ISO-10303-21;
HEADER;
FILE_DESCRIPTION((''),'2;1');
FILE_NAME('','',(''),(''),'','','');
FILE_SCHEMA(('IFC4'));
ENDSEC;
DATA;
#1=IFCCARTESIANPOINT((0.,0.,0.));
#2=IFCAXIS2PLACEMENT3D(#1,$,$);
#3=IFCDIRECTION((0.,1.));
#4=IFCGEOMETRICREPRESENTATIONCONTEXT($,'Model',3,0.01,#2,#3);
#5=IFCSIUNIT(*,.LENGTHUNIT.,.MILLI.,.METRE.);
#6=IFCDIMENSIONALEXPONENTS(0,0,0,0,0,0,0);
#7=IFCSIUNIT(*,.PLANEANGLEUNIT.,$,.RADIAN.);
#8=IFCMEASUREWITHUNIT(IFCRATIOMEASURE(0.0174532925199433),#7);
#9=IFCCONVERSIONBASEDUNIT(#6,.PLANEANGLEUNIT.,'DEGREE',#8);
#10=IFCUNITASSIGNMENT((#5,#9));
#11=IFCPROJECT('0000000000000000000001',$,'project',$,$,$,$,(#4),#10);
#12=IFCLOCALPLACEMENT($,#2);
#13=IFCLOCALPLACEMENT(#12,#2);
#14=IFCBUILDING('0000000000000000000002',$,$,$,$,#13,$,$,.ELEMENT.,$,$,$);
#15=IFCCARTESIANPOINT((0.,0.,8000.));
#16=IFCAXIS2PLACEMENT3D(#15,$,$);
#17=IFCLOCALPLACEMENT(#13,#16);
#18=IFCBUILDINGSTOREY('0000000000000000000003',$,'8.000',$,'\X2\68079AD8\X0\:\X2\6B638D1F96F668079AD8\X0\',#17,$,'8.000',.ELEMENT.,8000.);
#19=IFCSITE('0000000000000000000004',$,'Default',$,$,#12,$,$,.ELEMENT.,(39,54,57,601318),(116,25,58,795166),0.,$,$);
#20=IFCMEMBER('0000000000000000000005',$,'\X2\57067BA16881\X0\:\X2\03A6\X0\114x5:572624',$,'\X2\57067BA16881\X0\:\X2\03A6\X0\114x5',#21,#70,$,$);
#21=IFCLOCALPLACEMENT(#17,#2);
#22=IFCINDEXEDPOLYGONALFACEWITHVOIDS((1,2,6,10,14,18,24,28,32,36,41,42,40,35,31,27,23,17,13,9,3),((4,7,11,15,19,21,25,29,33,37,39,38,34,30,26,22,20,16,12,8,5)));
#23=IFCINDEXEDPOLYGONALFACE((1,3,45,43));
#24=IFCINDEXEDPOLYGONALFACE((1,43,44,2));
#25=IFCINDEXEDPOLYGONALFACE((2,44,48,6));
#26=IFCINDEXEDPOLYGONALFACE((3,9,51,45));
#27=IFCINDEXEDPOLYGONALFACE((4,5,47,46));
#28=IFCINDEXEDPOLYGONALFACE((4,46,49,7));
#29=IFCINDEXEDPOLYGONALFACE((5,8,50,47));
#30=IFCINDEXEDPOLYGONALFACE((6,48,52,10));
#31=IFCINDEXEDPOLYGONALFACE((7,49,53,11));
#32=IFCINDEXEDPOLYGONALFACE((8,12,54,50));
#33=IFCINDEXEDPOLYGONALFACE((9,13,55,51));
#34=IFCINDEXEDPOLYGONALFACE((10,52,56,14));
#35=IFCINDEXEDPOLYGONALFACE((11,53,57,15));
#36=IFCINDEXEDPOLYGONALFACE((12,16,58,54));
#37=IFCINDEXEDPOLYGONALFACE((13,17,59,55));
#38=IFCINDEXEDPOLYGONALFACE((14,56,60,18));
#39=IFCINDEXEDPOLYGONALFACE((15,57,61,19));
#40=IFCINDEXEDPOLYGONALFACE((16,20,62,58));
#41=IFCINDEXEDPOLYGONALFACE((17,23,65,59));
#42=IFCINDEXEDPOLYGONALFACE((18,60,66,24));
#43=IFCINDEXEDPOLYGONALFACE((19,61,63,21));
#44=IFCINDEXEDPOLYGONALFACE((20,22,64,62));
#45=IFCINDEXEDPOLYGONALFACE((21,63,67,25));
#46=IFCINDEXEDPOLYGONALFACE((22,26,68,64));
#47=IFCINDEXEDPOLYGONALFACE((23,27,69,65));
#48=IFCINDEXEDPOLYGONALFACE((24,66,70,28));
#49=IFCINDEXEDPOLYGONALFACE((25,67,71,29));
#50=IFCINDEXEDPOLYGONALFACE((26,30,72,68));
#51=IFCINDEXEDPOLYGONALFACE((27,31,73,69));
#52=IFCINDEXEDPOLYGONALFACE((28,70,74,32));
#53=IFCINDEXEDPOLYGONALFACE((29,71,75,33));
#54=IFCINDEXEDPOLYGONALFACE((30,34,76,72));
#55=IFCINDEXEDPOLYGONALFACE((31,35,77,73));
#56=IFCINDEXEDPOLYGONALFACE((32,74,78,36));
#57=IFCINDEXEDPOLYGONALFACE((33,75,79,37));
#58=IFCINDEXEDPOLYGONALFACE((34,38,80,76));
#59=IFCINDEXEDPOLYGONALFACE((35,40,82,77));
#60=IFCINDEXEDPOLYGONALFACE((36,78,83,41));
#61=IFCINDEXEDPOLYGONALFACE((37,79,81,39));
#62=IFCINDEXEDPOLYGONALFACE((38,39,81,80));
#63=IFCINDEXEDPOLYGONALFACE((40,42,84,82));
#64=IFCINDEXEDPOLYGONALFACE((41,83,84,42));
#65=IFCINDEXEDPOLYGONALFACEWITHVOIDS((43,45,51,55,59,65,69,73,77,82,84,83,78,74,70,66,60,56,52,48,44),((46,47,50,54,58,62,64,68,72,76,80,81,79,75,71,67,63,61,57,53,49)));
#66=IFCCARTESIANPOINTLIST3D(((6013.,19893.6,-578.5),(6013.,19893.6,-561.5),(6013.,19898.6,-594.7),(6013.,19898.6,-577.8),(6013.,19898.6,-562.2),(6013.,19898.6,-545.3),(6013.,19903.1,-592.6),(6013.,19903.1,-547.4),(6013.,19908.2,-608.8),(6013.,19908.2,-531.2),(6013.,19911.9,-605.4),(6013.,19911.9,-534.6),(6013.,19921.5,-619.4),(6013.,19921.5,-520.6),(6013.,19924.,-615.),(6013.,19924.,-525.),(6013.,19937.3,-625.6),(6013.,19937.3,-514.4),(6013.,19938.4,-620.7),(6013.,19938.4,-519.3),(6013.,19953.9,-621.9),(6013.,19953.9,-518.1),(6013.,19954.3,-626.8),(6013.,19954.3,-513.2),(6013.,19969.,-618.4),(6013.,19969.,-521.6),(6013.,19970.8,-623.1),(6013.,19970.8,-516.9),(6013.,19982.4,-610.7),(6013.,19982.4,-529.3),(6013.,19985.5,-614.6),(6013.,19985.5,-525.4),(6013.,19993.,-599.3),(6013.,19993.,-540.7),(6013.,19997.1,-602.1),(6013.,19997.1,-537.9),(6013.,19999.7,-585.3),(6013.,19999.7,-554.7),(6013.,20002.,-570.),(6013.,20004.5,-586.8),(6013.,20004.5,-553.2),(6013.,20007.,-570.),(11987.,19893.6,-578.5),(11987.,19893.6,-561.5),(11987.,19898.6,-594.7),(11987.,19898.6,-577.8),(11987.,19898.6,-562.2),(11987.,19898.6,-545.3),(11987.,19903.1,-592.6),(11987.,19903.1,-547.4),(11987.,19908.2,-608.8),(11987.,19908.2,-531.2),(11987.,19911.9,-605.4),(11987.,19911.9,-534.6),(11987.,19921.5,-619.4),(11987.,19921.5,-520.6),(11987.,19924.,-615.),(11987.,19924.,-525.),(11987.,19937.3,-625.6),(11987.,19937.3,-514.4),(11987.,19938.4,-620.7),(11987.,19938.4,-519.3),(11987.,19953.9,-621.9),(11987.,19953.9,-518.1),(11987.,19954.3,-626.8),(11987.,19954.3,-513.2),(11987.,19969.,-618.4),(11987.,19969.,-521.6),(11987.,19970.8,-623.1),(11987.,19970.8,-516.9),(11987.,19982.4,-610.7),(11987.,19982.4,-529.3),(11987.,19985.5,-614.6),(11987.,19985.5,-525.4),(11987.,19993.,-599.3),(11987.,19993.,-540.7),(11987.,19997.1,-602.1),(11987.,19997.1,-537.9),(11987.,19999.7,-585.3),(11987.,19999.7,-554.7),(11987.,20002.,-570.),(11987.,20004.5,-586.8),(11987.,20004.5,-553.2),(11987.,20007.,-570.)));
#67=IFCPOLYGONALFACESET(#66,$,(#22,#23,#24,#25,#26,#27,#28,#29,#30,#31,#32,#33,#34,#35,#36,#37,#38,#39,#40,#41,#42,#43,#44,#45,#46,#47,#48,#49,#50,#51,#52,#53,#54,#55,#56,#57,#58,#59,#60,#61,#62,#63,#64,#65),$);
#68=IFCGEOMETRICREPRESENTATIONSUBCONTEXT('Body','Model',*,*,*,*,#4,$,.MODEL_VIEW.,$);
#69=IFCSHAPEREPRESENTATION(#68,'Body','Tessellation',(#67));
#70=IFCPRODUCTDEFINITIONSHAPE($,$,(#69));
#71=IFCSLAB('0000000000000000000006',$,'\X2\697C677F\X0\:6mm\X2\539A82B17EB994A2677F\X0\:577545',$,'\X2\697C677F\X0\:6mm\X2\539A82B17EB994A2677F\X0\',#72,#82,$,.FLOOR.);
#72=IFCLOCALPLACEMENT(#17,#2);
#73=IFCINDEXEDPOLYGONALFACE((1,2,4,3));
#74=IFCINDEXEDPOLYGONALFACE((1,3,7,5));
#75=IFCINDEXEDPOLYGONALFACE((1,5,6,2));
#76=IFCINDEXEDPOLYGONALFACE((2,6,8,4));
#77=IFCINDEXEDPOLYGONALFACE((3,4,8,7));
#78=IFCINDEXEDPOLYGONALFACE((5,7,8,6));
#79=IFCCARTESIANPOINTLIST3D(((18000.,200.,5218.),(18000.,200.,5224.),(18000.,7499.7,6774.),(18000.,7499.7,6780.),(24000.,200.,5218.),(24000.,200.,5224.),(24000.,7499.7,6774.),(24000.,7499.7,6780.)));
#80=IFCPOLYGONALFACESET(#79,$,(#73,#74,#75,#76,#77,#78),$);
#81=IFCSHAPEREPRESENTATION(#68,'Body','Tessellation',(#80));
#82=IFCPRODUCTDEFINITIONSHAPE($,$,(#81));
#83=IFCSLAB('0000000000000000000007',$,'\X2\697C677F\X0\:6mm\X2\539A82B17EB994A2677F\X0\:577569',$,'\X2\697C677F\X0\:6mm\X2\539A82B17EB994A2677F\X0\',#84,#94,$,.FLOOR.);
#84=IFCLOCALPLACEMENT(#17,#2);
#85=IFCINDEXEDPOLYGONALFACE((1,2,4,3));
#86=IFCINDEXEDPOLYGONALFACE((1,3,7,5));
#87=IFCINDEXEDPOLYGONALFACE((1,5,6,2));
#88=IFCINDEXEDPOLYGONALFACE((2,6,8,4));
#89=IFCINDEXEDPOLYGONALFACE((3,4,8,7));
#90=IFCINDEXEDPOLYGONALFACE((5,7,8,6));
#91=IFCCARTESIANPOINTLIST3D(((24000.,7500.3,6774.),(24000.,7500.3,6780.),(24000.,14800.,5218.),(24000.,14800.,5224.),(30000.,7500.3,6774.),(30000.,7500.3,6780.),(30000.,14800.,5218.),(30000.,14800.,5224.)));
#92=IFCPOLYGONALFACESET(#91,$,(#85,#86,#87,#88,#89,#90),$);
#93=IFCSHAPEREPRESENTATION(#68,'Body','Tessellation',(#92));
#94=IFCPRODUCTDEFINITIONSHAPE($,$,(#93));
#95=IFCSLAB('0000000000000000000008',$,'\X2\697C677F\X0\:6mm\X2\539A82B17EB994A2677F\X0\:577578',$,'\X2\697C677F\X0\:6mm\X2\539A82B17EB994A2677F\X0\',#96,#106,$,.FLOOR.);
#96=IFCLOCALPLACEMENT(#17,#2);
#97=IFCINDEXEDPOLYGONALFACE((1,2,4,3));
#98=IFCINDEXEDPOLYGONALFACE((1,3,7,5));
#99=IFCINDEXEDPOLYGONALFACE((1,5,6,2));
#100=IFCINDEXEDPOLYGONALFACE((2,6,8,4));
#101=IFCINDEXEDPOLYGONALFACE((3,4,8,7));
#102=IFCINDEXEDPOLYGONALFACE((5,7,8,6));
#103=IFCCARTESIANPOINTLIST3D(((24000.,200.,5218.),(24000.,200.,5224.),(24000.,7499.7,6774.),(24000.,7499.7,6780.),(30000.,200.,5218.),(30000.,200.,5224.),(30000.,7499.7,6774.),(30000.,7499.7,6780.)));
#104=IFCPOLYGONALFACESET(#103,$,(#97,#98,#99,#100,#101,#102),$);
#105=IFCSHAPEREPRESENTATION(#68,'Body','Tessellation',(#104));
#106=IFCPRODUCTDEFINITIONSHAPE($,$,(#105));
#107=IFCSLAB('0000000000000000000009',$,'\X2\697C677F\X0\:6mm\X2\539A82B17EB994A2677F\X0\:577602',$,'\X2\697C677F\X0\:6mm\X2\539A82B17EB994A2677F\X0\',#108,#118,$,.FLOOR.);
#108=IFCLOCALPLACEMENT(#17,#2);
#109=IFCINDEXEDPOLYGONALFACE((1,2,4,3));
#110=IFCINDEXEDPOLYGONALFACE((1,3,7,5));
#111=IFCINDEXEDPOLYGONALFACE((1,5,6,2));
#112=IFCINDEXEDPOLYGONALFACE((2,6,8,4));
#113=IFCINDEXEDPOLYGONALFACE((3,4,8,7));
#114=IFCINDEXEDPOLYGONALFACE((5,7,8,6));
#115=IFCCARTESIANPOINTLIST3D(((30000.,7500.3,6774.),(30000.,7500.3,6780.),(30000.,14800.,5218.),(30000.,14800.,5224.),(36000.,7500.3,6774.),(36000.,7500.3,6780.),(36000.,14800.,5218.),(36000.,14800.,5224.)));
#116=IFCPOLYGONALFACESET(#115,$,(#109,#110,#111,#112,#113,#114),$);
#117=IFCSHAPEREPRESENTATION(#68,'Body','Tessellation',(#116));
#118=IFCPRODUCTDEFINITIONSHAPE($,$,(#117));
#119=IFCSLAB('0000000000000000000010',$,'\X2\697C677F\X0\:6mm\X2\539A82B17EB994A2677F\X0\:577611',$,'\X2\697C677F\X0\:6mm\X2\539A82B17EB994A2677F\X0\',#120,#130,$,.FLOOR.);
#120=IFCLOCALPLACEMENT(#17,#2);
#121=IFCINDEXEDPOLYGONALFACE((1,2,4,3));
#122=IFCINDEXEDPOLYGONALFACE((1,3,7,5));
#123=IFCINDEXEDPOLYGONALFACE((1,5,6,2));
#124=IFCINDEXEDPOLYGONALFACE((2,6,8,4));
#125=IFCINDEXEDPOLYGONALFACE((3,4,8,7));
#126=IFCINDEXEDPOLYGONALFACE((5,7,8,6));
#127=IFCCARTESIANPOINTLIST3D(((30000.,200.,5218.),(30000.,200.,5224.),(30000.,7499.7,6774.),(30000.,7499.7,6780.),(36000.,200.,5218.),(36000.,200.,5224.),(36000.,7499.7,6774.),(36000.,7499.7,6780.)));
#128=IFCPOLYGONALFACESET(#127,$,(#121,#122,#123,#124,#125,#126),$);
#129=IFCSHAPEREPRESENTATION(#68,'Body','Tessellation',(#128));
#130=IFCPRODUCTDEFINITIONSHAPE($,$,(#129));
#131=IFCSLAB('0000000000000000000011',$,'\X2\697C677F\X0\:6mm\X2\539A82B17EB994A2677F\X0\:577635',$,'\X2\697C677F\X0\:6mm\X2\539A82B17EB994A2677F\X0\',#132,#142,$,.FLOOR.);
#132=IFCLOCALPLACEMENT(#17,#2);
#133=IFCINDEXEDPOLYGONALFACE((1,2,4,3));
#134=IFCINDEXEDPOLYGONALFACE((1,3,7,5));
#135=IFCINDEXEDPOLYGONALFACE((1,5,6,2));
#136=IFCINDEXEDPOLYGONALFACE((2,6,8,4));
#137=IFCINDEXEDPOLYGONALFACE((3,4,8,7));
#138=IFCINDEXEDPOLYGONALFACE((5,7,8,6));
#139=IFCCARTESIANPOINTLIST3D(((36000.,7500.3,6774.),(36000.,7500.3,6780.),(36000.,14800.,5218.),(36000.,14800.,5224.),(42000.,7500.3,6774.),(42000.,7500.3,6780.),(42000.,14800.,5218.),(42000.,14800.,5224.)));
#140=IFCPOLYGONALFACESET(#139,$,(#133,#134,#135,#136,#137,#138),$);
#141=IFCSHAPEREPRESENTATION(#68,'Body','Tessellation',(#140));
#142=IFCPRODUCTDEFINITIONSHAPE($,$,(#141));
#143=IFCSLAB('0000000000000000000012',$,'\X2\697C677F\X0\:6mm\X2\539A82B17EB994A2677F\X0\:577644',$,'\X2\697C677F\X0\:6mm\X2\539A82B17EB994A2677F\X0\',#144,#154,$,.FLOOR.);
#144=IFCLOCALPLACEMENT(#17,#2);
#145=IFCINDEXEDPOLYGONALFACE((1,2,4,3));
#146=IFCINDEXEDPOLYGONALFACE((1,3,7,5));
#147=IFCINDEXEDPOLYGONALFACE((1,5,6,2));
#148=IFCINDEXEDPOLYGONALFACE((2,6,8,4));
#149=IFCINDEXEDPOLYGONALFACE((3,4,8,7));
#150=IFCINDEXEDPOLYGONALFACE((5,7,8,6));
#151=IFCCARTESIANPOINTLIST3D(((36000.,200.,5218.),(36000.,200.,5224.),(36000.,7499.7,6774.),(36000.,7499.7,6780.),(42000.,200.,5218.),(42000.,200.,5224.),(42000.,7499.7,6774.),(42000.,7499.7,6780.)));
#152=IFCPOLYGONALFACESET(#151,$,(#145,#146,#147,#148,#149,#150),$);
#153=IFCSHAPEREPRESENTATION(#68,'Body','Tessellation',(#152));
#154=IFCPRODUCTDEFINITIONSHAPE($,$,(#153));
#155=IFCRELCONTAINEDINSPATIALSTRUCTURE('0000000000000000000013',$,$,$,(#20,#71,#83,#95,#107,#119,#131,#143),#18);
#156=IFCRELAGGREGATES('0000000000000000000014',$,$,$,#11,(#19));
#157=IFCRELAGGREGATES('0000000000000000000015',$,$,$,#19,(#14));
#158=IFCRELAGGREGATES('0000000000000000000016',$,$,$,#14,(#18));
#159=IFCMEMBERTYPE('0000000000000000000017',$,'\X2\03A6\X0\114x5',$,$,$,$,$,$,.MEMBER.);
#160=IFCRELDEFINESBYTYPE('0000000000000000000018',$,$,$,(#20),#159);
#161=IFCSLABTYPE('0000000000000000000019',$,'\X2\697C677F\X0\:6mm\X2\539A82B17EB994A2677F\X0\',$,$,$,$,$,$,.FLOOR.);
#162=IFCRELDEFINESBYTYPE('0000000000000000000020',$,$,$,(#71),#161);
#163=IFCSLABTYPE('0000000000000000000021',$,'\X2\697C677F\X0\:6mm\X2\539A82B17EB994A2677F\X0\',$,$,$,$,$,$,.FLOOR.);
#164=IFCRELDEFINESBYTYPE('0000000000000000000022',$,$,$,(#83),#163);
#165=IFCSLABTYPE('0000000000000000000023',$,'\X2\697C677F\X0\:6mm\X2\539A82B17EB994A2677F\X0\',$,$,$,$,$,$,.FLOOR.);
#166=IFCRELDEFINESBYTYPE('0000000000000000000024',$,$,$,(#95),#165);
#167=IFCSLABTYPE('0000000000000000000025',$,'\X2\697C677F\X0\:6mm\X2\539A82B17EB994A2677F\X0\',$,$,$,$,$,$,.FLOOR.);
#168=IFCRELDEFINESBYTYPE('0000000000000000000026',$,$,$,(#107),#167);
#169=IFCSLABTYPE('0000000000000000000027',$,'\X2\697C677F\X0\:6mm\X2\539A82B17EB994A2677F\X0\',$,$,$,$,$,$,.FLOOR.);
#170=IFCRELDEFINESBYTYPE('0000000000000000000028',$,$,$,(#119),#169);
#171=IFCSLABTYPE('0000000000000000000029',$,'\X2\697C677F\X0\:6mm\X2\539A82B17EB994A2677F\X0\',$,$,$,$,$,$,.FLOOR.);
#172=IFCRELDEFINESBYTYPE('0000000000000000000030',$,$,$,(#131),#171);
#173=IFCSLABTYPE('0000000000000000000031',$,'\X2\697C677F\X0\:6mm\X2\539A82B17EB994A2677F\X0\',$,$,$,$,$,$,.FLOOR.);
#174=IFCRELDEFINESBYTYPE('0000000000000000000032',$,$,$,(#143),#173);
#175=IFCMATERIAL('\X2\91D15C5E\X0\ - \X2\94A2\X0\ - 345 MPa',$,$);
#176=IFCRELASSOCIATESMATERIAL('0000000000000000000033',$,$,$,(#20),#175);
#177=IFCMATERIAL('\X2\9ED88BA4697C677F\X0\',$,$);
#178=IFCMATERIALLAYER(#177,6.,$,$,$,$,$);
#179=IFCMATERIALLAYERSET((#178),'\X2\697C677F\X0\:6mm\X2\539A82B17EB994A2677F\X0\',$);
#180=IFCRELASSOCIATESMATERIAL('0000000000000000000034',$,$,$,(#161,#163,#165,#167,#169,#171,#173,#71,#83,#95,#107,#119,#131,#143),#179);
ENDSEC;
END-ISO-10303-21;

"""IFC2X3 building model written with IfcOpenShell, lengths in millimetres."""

from ifc_helpers import new_model, entity, si_unit, converted_unit, direction, frame, frame_2d, origin, place, context, subcontext, project, spatial, rectangle, hollow_circle, extrude, clip, halfspace, source, transform, mapped, material, layer, layer_set, layer_usage, type_object, type_shapes, element, save


model = new_model("IFC2X3")

# Units and contexts
model_context = context("Model", 3, precision=0.01, world=origin(), true_north=direction((0.0, 1.0)))
body_context = subcontext(model_context, "Body", "Model", "MODEL_VIEW")
ifc_project = project(units=[si_unit("LENGTHUNIT", "METRE", prefix="MILLI"), converted_unit("PLANEANGLEUNIT", "DEGREE", entity("IfcRatioMeasure", 0.0174532925199433), si_unit("PLANEANGLEUNIT", "RADIAN"), dimensions=[0, 0, 0, 0, 0, 0, 0])], contexts=[model_context])

# Site, building, storey
site_placement = place(None, origin())
site = spatial("IfcSite", under=ifc_project, at=site_placement, Name="Default", CompositionType="ELEMENT", RefLatitude=(39, 54, 57, 601318), RefLongitude=(116, 25, 58, 795166), RefElevation=0.0)
building_placement = place(site_placement, origin())
building = spatial("IfcBuilding", under=site, at=building_placement, CompositionType="ELEMENT")
storey_placement = place(building_placement, frame((0.0, 0.0, 8000.0)))
storey = spatial("IfcBuildingStorey", under=building, at=storey_placement, Name="8.000", ObjectType="标高:正负零标高", LongName="8.000", CompositionType="ELEMENT", Elevation=8000.0)

# Shared definitions
ifc_material_1 = material(Name="金属 - 钢 - 345 MPa")

# Member
member_type_1 = type_object("IfcMemberType", Name="Φ114x5", PredefinedType="MEMBER")
shared_shape_1 = source(origin(), body_context, "Body", "SweptSolid", [
    extrude(hollow_circle(Radius=57.0, WallThickness=5.0, at=frame_2d((0.0, 0.0), x_axis=(1.0, 0.0))), frame((-2987.0, 0.0, 0.0), z_axis=(1.0, 0.0, 0.0), x_axis=(0.0, 1.0, 0.0)), (0.0, 0.0, 1.0), 5974.0),
])
type_shapes(member_type_1, [shared_shape_1])
for number, where, name in (
    (1, (9000.0, 19950.0, -570.0), "圆管梁:Φ114x5:572624"),
):
    element("IfcMember", number, at=place(storey_placement, frame(where)), inside=storey, type_object=member_type_1, material=ifc_material_1, Name=name, ObjectType="圆管梁:Φ114x5", context=body_context, shape_type="MappedRepresentation", body=[
        mapped(shared_shape_1, transform((0.0, 0.0, 0.0), scale=1.0)),
    ])

# Slabs
ifc_material_2 = material(Name="默认楼板")
ifc_layer_1 = layer(ifc_material_2, 6.0)
ifc_layer_set_1 = layer_set([ifc_layer_1], Name="楼板:6mm厚花纹钢板")
ifc_layer_usage_1 = layer_usage(ifc_layer_set_1, "AXIS3", "POSITIVE", 0.0)
slab_type_1 = type_object("IfcSlabType", Name="楼板:6mm厚花纹钢板", PredefinedType="FLOOR", material=ifc_layer_set_1)
slab_1_placement = place(storey_placement, origin())
element("IfcSlab", 2, at=slab_1_placement, inside=storey, type_object=slab_type_1, material=ifc_layer_usage_1, Name="楼板:6mm厚花纹钢板:577545", ObjectType="楼板:6mm厚花纹钢板", PredefinedType="FLOOR", context=body_context, shape_type="Clipping", body=[
    clip(clip(extrude(rectangle(XDim=7463.7, YDim=6000.0, at=frame_2d((0.0, 0.0), x_axis=(1.0, 0.0))), frame((21000.0, 3849.8, 6002.0), z_axis=(0.0, 0.208477, -0.978027), x_axis=(0.0, 0.978027, 0.208477)), (-0.208477, 0.0, 0.978027), 6.1), halfspace(frame((21000.0, 3849.8, 5996.0), z_axis=(0.0, 0.208477, -0.978027), x_axis=(0.0, -0.978027, -0.208477)), False)), halfspace(frame((21000.0, 3849.8, 6002.0), z_axis=(0.0, -0.208477, 0.978027), x_axis=(0.0, -0.978027, -0.208477)), False)),
])
ifc_layer_usage_2 = layer_usage(ifc_layer_set_1, "AXIS3", "POSITIVE", 0.0)
slab_type_2 = type_object("IfcSlabType", Name="楼板:6mm厚花纹钢板", PredefinedType="FLOOR", material=ifc_layer_set_1)
slab_2_placement = place(storey_placement, origin())
element("IfcSlab", 3, at=slab_2_placement, inside=storey, type_object=slab_type_2, material=ifc_layer_usage_2, Name="楼板:6mm厚花纹钢板:577569", ObjectType="楼板:6mm厚花纹钢板", PredefinedType="FLOOR", context=body_context, shape_type="Clipping", body=[
    clip(clip(extrude(rectangle(XDim=7463.7, YDim=6000.0, at=frame_2d((0.0, 0.0), x_axis=(1.0, 0.0))), frame((27000.0, 11150.2, 6002.0), z_axis=(0.0, -0.208477, -0.978027), x_axis=(0.0, 0.978027, -0.208477)), (0.208477, 0.0, 0.978027), 6.1), halfspace(frame((27000.0, 11150.2, 5996.0), z_axis=(0.0, -0.208477, -0.978027), x_axis=(0.0, -0.978027, 0.208477)), False)), halfspace(frame((27000.0, 11150.2, 6002.0), z_axis=(0.0, 0.208477, 0.978027), x_axis=(0.0, -0.978027, 0.208477)), False)),
])
ifc_layer_usage_3 = layer_usage(ifc_layer_set_1, "AXIS3", "POSITIVE", 0.0)
slab_type_3 = type_object("IfcSlabType", Name="楼板:6mm厚花纹钢板", PredefinedType="FLOOR", material=ifc_layer_set_1)
slab_3_placement = place(storey_placement, origin())
element("IfcSlab", 4, at=slab_3_placement, inside=storey, type_object=slab_type_3, material=ifc_layer_usage_3, Name="楼板:6mm厚花纹钢板:577578", ObjectType="楼板:6mm厚花纹钢板", PredefinedType="FLOOR", context=body_context, shape_type="Clipping", body=[
    clip(clip(extrude(rectangle(XDim=7463.7, YDim=6000.0, at=frame_2d((0.0, 0.0), x_axis=(1.0, 0.0))), frame((27000.0, 3849.8, 6002.0), z_axis=(0.0, 0.208477, -0.978027), x_axis=(0.0, 0.978027, 0.208477)), (-0.208477, 0.0, 0.978027), 6.1), halfspace(frame((27000.0, 3849.8, 5996.0), z_axis=(0.0, 0.208477, -0.978027), x_axis=(0.0, -0.978027, -0.208477)), False)), halfspace(frame((27000.0, 3849.8, 6002.0), z_axis=(0.0, -0.208477, 0.978027), x_axis=(0.0, -0.978027, -0.208477)), False)),
])
ifc_layer_usage_4 = layer_usage(ifc_layer_set_1, "AXIS3", "POSITIVE", 0.0)
slab_type_4 = type_object("IfcSlabType", Name="楼板:6mm厚花纹钢板", PredefinedType="FLOOR", material=ifc_layer_set_1)
slab_4_placement = place(storey_placement, origin())
element("IfcSlab", 5, at=slab_4_placement, inside=storey, type_object=slab_type_4, material=ifc_layer_usage_4, Name="楼板:6mm厚花纹钢板:577602", ObjectType="楼板:6mm厚花纹钢板", PredefinedType="FLOOR", context=body_context, shape_type="Clipping", body=[
    clip(clip(extrude(rectangle(XDim=7463.7, YDim=6000.0, at=frame_2d((0.0, 0.0), x_axis=(1.0, 0.0))), frame((33000.0, 11150.2, 6002.0), z_axis=(0.0, -0.208477, -0.978027), x_axis=(0.0, 0.978027, -0.208477)), (0.208477, 0.0, 0.978027), 6.1), halfspace(frame((33000.0, 11150.2, 5996.0), z_axis=(0.0, -0.208477, -0.978027), x_axis=(0.0, -0.978027, 0.208477)), False)), halfspace(frame((33000.0, 11150.2, 6002.0), z_axis=(0.0, 0.208477, 0.978027), x_axis=(0.0, -0.978027, 0.208477)), False)),
])
ifc_layer_usage_5 = layer_usage(ifc_layer_set_1, "AXIS3", "POSITIVE", 0.0)
slab_type_5 = type_object("IfcSlabType", Name="楼板:6mm厚花纹钢板", PredefinedType="FLOOR", material=ifc_layer_set_1)
slab_5_placement = place(storey_placement, origin())
element("IfcSlab", 6, at=slab_5_placement, inside=storey, type_object=slab_type_5, material=ifc_layer_usage_5, Name="楼板:6mm厚花纹钢板:577611", ObjectType="楼板:6mm厚花纹钢板", PredefinedType="FLOOR", context=body_context, shape_type="Clipping", body=[
    clip(clip(extrude(rectangle(XDim=7463.7, YDim=6000.0, at=frame_2d((0.0, 0.0), x_axis=(1.0, 0.0))), frame((33000.0, 3849.8, 6002.0), z_axis=(0.0, 0.208477, -0.978027), x_axis=(0.0, 0.978027, 0.208477)), (-0.208477, 0.0, 0.978027), 6.1), halfspace(frame((33000.0, 3849.8, 5996.0), z_axis=(0.0, 0.208477, -0.978027), x_axis=(0.0, -0.978027, -0.208477)), False)), halfspace(frame((33000.0, 3849.8, 6002.0), z_axis=(0.0, -0.208477, 0.978027), x_axis=(0.0, -0.978027, -0.208477)), False)),
])
ifc_layer_usage_6 = layer_usage(ifc_layer_set_1, "AXIS3", "POSITIVE", 0.0)
slab_type_6 = type_object("IfcSlabType", Name="楼板:6mm厚花纹钢板", PredefinedType="FLOOR", material=ifc_layer_set_1)
slab_6_placement = place(storey_placement, origin())
element("IfcSlab", 7, at=slab_6_placement, inside=storey, type_object=slab_type_6, material=ifc_layer_usage_6, Name="楼板:6mm厚花纹钢板:577635", ObjectType="楼板:6mm厚花纹钢板", PredefinedType="FLOOR", context=body_context, shape_type="Clipping", body=[
    clip(clip(extrude(rectangle(XDim=7463.7, YDim=6000.0, at=frame_2d((0.0, 0.0), x_axis=(1.0, 0.0))), frame((39000.0, 11150.2, 6002.0), z_axis=(0.0, -0.208477, -0.978027), x_axis=(0.0, 0.978027, -0.208477)), (0.208477, 0.0, 0.978027), 6.1), halfspace(frame((39000.0, 11150.2, 5996.0), z_axis=(0.0, -0.208477, -0.978027), x_axis=(0.0, -0.978027, 0.208477)), False)), halfspace(frame((39000.0, 11150.2, 6002.0), z_axis=(0.0, 0.208477, 0.978027), x_axis=(0.0, -0.978027, 0.208477)), False)),
])
ifc_layer_usage_7 = layer_usage(ifc_layer_set_1, "AXIS3", "POSITIVE", 0.0)
slab_type_7 = type_object("IfcSlabType", Name="楼板:6mm厚花纹钢板", PredefinedType="FLOOR", material=ifc_layer_set_1)
slab_7_placement = place(storey_placement, origin())
element("IfcSlab", 8, at=slab_7_placement, inside=storey, type_object=slab_type_7, material=ifc_layer_usage_7, Name="楼板:6mm厚花纹钢板:577644", ObjectType="楼板:6mm厚花纹钢板", PredefinedType="FLOOR", context=body_context, shape_type="Clipping", body=[
    clip(clip(extrude(rectangle(XDim=7463.7, YDim=6000.0, at=frame_2d((0.0, 0.0), x_axis=(1.0, 0.0))), frame((39000.0, 3849.8, 6002.0), z_axis=(0.0, 0.208477, -0.978027), x_axis=(0.0, 0.978027, 0.208477)), (-0.208477, 0.0, 0.978027), 6.1), halfspace(frame((39000.0, 3849.8, 5996.0), z_axis=(0.0, 0.208477, -0.978027), x_axis=(0.0, -0.978027, -0.208477)), False)), halfspace(frame((39000.0, 3849.8, 6002.0), z_axis=(0.0, -0.208477, 0.978027), x_axis=(0.0, -0.978027, -0.208477)), False)),
])

save(model, "model.ifc")
